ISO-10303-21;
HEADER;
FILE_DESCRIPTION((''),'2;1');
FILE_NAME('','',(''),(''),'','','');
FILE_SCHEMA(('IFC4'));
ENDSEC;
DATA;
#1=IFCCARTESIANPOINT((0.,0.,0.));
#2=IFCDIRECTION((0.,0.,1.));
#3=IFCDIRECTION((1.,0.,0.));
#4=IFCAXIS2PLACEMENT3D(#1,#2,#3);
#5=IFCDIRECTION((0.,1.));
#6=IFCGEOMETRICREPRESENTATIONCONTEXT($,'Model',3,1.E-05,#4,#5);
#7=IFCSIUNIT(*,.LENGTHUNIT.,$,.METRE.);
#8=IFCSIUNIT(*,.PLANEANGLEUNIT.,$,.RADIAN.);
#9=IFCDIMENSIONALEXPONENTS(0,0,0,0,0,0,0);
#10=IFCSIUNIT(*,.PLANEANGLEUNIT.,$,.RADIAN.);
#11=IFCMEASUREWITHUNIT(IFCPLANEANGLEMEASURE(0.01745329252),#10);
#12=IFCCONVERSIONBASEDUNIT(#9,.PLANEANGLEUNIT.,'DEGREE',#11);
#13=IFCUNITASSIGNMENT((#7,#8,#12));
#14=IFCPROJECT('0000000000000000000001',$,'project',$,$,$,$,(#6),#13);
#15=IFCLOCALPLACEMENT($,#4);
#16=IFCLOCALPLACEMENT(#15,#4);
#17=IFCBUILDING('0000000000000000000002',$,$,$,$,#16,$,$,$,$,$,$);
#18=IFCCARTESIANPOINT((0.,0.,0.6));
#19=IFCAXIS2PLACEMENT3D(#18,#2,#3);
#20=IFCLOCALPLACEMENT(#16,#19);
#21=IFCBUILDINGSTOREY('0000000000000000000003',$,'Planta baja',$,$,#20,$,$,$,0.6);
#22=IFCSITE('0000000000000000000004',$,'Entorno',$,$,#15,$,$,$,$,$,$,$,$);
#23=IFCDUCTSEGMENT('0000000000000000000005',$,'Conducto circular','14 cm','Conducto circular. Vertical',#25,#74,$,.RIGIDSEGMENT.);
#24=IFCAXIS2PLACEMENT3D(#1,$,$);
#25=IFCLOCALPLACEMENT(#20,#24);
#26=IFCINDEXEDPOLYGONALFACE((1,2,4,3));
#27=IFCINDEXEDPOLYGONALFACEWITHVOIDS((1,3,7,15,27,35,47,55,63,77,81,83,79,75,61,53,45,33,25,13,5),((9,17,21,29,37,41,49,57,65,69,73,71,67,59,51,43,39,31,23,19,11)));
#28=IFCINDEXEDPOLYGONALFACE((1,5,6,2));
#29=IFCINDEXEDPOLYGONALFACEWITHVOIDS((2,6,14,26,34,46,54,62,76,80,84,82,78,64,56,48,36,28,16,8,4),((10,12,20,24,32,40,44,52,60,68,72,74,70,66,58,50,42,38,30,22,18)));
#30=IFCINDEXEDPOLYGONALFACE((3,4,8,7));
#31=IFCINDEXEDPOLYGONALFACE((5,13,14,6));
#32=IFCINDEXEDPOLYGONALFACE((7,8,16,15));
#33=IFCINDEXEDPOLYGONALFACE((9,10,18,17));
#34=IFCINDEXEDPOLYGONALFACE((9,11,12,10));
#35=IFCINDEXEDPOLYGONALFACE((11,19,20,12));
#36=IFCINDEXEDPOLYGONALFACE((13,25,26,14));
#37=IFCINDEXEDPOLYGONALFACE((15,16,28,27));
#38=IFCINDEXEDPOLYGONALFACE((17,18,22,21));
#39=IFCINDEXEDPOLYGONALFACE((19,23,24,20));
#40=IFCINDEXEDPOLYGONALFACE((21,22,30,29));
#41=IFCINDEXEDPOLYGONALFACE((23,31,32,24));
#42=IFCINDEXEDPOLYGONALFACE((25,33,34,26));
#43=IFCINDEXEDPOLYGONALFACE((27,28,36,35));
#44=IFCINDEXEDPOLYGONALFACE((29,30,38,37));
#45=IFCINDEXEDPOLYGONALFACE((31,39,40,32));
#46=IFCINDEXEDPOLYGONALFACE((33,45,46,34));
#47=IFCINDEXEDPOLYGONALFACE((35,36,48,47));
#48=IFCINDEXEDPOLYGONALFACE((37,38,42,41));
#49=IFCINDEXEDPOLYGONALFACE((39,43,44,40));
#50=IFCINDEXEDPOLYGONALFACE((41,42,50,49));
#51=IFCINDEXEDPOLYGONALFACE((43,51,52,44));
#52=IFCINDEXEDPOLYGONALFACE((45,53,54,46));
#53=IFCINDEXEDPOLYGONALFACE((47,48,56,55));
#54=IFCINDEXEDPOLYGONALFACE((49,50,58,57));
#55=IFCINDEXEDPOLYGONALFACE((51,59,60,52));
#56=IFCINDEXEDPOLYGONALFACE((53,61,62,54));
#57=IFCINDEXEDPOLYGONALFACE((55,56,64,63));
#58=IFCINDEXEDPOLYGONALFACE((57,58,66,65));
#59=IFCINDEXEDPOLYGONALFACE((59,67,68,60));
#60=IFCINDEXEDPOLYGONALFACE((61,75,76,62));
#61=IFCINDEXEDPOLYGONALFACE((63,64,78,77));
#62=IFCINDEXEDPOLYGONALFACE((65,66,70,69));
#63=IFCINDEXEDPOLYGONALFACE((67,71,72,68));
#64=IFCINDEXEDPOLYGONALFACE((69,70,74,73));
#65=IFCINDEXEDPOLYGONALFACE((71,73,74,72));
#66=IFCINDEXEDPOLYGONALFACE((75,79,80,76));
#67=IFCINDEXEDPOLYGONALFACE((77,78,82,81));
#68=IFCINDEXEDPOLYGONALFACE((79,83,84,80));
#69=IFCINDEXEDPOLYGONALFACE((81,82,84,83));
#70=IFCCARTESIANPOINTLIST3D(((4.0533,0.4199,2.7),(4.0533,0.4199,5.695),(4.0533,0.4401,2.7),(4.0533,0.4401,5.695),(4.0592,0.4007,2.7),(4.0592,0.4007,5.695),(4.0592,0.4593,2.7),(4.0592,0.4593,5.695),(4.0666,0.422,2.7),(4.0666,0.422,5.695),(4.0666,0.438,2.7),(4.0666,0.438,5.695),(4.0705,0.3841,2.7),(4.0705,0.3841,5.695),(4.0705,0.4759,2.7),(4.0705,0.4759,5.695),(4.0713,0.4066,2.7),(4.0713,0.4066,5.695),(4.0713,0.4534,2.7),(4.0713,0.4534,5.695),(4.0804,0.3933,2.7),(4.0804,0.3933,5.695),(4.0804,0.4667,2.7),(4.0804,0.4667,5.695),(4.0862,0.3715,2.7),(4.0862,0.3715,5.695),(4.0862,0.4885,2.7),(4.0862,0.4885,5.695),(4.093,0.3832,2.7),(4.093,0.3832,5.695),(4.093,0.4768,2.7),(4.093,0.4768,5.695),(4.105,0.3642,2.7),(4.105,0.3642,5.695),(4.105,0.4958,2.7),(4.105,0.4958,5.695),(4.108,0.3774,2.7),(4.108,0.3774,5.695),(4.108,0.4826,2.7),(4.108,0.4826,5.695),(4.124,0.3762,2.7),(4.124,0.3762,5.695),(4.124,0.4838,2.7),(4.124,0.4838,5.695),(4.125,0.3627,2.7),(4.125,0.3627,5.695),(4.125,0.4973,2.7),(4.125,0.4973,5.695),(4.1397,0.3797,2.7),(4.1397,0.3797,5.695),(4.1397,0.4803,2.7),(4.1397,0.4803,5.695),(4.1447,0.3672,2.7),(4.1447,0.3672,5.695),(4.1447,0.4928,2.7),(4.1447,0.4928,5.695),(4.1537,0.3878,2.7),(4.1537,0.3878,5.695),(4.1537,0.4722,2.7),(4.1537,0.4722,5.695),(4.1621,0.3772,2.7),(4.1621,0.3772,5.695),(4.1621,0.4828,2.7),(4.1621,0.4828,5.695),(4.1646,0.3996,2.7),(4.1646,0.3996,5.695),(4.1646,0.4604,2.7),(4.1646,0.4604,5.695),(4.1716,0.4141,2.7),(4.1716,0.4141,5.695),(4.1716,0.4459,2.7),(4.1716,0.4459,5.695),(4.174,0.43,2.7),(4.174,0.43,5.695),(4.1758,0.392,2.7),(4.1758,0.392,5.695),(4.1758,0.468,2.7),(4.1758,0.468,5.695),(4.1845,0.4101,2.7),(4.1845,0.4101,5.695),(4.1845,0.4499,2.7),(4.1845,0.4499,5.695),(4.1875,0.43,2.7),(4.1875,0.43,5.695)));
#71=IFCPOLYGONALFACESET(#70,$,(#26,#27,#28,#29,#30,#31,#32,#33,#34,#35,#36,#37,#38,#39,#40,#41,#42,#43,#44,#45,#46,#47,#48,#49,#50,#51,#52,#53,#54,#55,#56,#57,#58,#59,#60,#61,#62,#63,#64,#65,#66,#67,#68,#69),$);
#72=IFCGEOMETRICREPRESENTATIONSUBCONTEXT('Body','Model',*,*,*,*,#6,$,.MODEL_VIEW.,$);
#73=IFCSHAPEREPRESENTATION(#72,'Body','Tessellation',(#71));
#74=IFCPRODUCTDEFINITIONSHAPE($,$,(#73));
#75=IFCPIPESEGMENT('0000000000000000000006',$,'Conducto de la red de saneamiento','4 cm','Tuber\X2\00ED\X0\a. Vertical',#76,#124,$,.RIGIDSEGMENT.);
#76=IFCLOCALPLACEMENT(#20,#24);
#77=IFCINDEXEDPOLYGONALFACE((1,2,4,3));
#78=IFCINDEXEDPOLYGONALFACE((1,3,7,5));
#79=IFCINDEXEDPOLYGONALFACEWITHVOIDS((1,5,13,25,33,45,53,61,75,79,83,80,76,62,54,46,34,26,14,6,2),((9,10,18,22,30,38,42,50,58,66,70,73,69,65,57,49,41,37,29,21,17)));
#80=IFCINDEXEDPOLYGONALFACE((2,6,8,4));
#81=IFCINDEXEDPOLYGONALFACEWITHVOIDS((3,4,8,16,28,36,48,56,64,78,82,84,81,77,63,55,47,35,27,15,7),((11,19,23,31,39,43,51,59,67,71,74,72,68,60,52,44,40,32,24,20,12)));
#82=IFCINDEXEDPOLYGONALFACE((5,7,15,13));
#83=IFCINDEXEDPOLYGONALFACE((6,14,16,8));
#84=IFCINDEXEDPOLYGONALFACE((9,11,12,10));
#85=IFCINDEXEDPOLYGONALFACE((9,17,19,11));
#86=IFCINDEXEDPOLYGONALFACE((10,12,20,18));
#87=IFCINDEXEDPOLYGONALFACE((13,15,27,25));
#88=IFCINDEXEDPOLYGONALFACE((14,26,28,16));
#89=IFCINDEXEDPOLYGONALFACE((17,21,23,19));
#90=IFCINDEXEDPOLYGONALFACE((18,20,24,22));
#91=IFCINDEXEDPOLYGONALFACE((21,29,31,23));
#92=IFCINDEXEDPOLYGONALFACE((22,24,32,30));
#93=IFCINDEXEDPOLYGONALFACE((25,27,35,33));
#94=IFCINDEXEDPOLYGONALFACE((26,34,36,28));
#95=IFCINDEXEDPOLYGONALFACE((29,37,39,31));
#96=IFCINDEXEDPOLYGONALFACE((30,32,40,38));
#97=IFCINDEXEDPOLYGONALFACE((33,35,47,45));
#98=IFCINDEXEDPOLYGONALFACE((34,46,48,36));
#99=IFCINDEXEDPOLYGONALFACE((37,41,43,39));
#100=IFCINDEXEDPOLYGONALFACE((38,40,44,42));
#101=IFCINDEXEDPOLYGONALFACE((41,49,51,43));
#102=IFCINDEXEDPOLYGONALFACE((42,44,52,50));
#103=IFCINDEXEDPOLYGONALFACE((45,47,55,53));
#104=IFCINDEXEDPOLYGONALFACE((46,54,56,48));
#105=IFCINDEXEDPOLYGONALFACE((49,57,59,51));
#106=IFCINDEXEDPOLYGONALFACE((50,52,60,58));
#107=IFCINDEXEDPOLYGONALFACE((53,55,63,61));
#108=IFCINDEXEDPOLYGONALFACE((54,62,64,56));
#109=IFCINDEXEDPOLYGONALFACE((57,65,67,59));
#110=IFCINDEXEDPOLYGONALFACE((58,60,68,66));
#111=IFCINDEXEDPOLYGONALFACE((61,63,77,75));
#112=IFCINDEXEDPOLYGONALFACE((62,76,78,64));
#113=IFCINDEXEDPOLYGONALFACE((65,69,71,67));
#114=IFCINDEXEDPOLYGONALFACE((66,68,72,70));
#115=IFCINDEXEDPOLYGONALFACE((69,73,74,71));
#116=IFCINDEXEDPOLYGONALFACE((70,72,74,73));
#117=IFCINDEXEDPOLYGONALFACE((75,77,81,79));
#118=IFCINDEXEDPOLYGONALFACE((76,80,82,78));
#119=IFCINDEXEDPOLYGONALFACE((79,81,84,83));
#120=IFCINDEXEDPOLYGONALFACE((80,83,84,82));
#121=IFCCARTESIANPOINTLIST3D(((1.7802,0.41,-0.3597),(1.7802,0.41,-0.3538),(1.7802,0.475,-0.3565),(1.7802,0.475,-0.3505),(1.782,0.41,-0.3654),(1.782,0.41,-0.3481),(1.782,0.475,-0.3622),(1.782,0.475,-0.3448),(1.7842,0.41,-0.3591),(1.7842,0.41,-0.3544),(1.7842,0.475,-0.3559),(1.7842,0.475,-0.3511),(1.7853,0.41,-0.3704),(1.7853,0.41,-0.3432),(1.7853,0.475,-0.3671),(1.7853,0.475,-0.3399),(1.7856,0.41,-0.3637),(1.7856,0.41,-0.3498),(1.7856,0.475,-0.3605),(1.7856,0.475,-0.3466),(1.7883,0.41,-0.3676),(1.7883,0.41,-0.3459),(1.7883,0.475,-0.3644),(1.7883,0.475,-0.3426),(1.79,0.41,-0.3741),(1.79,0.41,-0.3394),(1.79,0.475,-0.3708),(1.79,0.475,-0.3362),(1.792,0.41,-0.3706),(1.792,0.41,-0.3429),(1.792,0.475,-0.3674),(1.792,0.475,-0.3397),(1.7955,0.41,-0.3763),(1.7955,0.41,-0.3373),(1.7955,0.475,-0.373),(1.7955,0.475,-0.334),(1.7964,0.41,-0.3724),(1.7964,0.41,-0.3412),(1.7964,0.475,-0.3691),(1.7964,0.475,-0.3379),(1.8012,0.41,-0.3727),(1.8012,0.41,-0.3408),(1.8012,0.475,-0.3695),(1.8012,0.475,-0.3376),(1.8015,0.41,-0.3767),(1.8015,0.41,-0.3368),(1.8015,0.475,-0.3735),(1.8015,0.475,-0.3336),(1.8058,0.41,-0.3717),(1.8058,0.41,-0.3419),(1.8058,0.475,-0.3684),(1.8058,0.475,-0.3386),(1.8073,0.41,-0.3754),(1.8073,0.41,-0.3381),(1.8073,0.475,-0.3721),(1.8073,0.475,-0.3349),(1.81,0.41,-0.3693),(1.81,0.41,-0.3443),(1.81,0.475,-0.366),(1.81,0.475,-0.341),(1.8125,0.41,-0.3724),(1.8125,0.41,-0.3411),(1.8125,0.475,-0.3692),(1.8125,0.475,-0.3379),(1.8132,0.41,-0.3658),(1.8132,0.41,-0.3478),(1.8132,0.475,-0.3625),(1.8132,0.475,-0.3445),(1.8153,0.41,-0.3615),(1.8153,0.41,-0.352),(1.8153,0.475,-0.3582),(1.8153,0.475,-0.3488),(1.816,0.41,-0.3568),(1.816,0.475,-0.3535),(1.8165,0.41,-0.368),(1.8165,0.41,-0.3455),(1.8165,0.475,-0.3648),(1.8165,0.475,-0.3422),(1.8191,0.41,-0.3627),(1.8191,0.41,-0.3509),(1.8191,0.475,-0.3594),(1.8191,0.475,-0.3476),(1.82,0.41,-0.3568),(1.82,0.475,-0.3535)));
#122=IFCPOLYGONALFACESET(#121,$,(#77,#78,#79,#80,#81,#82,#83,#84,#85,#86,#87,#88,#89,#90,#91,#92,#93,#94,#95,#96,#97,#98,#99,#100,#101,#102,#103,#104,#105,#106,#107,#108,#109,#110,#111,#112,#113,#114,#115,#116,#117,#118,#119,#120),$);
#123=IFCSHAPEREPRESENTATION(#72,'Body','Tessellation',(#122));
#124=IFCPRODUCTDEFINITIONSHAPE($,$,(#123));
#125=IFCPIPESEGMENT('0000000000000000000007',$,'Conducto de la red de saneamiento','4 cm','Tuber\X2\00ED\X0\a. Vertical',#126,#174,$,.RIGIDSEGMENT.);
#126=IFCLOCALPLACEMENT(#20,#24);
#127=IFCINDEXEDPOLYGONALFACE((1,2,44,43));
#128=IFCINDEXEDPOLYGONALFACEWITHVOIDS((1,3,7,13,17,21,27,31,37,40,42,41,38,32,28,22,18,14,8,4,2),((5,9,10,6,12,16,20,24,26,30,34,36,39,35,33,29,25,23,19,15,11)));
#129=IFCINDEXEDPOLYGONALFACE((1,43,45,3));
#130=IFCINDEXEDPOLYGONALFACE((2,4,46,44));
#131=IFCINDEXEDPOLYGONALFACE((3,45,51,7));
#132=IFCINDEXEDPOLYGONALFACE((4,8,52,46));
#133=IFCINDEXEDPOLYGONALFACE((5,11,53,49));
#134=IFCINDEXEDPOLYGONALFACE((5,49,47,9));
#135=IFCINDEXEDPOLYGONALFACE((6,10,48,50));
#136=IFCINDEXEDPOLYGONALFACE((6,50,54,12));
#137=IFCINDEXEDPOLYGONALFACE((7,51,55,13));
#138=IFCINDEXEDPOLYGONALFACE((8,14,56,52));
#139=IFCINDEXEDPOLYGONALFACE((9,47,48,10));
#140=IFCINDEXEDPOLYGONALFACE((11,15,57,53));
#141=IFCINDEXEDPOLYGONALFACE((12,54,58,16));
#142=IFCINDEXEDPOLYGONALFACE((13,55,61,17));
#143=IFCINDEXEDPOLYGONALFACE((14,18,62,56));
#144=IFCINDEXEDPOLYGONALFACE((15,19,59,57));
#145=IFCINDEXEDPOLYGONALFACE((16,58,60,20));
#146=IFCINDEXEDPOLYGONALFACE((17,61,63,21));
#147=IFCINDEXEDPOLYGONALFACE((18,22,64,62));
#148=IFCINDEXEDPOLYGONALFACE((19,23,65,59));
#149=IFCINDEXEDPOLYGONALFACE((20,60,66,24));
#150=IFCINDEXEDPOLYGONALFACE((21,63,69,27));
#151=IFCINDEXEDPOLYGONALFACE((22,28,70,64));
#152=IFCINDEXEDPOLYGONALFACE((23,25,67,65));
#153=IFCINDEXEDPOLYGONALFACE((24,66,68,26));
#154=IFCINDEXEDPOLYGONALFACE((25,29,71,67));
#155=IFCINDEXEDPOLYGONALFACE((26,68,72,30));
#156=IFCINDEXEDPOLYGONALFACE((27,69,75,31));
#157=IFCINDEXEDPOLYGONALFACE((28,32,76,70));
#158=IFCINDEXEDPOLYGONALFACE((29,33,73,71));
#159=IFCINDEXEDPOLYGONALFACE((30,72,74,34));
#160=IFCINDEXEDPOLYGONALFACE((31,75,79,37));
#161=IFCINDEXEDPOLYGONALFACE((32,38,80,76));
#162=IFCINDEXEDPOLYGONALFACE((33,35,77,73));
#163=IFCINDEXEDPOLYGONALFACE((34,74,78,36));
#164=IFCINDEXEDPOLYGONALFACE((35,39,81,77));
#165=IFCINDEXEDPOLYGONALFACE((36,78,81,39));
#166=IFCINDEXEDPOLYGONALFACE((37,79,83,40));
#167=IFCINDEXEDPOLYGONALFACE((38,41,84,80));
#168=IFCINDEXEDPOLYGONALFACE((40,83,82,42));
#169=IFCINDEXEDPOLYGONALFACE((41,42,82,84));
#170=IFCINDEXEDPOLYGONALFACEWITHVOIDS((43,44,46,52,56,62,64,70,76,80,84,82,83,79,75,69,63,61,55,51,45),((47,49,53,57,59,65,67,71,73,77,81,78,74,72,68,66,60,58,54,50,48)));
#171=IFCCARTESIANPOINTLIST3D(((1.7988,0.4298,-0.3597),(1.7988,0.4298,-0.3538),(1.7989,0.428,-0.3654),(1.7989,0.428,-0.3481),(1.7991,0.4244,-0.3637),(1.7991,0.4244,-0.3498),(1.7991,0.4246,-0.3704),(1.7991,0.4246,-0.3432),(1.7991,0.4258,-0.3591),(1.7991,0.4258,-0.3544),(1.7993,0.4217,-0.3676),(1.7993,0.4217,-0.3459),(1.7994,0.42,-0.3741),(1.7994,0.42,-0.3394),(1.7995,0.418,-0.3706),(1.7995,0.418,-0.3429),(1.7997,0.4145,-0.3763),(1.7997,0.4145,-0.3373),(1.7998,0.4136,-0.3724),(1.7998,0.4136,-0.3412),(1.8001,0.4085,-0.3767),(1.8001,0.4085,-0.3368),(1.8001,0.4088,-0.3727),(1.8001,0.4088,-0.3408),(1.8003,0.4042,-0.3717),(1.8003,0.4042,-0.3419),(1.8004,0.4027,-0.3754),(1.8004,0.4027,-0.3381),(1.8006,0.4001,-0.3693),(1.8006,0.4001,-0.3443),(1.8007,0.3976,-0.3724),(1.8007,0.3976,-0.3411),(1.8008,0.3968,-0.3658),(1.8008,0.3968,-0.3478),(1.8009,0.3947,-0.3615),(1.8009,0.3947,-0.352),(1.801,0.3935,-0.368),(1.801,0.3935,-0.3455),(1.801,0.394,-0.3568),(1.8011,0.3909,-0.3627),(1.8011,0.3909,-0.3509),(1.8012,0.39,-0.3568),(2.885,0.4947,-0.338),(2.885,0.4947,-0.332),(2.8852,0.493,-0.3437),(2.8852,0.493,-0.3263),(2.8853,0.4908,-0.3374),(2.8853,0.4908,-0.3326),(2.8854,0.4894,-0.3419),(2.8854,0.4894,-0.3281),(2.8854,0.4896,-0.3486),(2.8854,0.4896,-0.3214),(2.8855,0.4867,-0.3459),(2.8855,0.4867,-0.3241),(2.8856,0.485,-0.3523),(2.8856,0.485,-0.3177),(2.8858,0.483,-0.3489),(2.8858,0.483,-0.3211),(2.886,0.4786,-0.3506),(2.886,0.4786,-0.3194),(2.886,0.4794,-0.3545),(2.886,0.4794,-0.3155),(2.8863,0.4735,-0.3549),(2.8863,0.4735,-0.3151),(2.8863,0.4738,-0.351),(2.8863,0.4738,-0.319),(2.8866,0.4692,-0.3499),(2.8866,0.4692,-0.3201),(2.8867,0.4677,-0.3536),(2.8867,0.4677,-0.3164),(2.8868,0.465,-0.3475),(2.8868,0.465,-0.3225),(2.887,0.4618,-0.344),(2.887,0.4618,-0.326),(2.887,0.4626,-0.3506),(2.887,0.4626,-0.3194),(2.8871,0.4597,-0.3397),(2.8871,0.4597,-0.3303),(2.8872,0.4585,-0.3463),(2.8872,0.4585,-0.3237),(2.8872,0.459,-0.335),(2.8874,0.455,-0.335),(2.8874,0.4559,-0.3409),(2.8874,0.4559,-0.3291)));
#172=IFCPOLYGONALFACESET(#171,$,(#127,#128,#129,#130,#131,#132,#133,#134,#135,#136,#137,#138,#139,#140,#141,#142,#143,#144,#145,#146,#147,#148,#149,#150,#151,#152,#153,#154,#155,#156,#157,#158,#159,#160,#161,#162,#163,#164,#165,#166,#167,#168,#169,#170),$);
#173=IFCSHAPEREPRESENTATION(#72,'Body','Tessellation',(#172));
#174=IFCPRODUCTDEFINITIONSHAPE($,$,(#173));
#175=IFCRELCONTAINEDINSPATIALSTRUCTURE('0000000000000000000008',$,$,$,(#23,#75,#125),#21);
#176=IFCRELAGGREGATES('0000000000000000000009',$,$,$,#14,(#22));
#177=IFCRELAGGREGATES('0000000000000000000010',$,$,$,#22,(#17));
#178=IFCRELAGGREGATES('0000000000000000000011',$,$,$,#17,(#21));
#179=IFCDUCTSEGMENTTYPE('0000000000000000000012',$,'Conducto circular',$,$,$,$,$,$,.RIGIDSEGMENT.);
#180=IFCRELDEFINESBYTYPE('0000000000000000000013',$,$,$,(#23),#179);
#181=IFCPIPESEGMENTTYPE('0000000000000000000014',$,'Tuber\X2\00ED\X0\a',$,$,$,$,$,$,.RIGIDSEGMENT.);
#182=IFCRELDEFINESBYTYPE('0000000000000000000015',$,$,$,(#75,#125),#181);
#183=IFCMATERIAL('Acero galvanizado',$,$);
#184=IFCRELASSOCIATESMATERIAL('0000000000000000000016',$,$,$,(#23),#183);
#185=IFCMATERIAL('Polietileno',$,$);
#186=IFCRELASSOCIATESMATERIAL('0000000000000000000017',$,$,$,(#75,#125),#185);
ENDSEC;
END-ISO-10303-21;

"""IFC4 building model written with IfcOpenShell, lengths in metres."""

from ifc_helpers import new_model, entity, si_unit, converted_unit, direction, frame, origin_with_axes, origin_2d_with_axis, place, context, subcontext, project, spatial, hollow_circle, extrude, material, type_object, element, save


model = new_model("IFC4")

# Units and contexts
model_context = context("Model", 3, precision=1e-05, world=origin_with_axes(), true_north=direction((0.0, 1.0)))
body_context = subcontext(model_context, "Body", "Model", "MODEL_VIEW")
ifc_project = project(units=[si_unit("LENGTHUNIT", "METRE"), si_unit("PLANEANGLEUNIT", "RADIAN"), converted_unit("PLANEANGLEUNIT", "DEGREE", entity("IfcPlaneAngleMeasure", 0.01745329252), si_unit("PLANEANGLEUNIT", "RADIAN"), dimensions=[0, 0, 0, 0, 0, 0, 0])], contexts=[model_context])

# Site, building, storey
site_placement = place(None, origin_with_axes())
site = spatial("IfcSite", under=ifc_project, at=site_placement, Name="Entorno")
building_placement = place(site_placement, origin_with_axes())
building = spatial("IfcBuilding", under=site, at=building_placement)
storey_placement = place(building_placement, frame((0.0, 0.0, 0.6), z_axis=(0.0, 0.0, 1.0), x_axis=(1.0, 0.0, 0.0)))
storey = spatial("IfcBuildingStorey", under=building, at=storey_placement, Name="Planta baja", Elevation=0.6)

# Shared definitions
ifc_material_1 = material(Name="Polietileno")

# Duct segment
ifc_material_2 = material(Name="Acero galvanizado")
duct_segment_type = type_object("IfcDuctSegmentType", Name="Conducto circular", PredefinedType="RIGIDSEGMENT")
duct_segment_1_placement = place(storey_placement, frame((4.12, 0.43, 2.7), z_axis=(0.0, 0.0, 1.0), x_axis=(1.0, 0.0, 0.0)))
element("IfcDuctSegment", 1, at=duct_segment_1_placement, inside=storey, type_object=duct_segment_type, material=ifc_material_2, Name="Conducto circular", Description="14 cm", ObjectType="Conducto circular. Vertical", PredefinedType="RIGIDSEGMENT", context=body_context, shape_type="SweptSolid", body=[
    extrude(hollow_circle(Radius=0.0675, WallThickness=0.0135, at=origin_2d_with_axis()), origin_with_axes(), (0.0, 0.0, 1.0), 2.995),
])

# Pipe segments
pipe_segment_type_1 = type_object("IfcPipeSegmentType", Name="Tubería", PredefinedType="RIGIDSEGMENT")
pipe_segment_1_placement = place(storey_placement, frame((1.8, 0.475, -0.3535), z_axis=(0.0, -1.0, 0.0), x_axis=(1.0, 0.0, 0.0)))
element("IfcPipeSegment", 2, at=pipe_segment_1_placement, inside=storey, type_object=pipe_segment_type_1, material=ifc_material_1, Name="Conducto de la red de saneamiento", Description="4 cm", ObjectType="Tubería. Vertical", PredefinedType="RIGIDSEGMENT", context=body_context, shape_type="SweptSolid", body=[
    extrude(hollow_circle(Radius=0.02, WallThickness=0.004, at=origin_2d_with_axis()), origin_with_axes(), (0.0, -0.049938, 0.998752), 0.0651),
])
pipe_segment_2_placement = place(storey_placement, frame((2.8862, 0.475, -0.335), z_axis=(-0.998215, -0.059724, 0.0), x_axis=(0.059724, -0.998215, 0.0)))
element("IfcPipeSegment", 3, at=pipe_segment_2_placement, inside=storey, type_object=pipe_segment_type_1, material=ifc_material_1, Name="Conducto de la red de saneamiento", Description="4 cm", ObjectType="Tubería. Vertical", PredefinedType="RIGIDSEGMENT", context=body_context, shape_type="SweptSolid", body=[
    extrude(hollow_circle(Radius=0.02, WallThickness=0.004, at=origin_2d_with_axis()), origin_with_axes(), (0.0, -0.019996, 0.9998), 1.0884),
])

save(model, "model.ifc")
